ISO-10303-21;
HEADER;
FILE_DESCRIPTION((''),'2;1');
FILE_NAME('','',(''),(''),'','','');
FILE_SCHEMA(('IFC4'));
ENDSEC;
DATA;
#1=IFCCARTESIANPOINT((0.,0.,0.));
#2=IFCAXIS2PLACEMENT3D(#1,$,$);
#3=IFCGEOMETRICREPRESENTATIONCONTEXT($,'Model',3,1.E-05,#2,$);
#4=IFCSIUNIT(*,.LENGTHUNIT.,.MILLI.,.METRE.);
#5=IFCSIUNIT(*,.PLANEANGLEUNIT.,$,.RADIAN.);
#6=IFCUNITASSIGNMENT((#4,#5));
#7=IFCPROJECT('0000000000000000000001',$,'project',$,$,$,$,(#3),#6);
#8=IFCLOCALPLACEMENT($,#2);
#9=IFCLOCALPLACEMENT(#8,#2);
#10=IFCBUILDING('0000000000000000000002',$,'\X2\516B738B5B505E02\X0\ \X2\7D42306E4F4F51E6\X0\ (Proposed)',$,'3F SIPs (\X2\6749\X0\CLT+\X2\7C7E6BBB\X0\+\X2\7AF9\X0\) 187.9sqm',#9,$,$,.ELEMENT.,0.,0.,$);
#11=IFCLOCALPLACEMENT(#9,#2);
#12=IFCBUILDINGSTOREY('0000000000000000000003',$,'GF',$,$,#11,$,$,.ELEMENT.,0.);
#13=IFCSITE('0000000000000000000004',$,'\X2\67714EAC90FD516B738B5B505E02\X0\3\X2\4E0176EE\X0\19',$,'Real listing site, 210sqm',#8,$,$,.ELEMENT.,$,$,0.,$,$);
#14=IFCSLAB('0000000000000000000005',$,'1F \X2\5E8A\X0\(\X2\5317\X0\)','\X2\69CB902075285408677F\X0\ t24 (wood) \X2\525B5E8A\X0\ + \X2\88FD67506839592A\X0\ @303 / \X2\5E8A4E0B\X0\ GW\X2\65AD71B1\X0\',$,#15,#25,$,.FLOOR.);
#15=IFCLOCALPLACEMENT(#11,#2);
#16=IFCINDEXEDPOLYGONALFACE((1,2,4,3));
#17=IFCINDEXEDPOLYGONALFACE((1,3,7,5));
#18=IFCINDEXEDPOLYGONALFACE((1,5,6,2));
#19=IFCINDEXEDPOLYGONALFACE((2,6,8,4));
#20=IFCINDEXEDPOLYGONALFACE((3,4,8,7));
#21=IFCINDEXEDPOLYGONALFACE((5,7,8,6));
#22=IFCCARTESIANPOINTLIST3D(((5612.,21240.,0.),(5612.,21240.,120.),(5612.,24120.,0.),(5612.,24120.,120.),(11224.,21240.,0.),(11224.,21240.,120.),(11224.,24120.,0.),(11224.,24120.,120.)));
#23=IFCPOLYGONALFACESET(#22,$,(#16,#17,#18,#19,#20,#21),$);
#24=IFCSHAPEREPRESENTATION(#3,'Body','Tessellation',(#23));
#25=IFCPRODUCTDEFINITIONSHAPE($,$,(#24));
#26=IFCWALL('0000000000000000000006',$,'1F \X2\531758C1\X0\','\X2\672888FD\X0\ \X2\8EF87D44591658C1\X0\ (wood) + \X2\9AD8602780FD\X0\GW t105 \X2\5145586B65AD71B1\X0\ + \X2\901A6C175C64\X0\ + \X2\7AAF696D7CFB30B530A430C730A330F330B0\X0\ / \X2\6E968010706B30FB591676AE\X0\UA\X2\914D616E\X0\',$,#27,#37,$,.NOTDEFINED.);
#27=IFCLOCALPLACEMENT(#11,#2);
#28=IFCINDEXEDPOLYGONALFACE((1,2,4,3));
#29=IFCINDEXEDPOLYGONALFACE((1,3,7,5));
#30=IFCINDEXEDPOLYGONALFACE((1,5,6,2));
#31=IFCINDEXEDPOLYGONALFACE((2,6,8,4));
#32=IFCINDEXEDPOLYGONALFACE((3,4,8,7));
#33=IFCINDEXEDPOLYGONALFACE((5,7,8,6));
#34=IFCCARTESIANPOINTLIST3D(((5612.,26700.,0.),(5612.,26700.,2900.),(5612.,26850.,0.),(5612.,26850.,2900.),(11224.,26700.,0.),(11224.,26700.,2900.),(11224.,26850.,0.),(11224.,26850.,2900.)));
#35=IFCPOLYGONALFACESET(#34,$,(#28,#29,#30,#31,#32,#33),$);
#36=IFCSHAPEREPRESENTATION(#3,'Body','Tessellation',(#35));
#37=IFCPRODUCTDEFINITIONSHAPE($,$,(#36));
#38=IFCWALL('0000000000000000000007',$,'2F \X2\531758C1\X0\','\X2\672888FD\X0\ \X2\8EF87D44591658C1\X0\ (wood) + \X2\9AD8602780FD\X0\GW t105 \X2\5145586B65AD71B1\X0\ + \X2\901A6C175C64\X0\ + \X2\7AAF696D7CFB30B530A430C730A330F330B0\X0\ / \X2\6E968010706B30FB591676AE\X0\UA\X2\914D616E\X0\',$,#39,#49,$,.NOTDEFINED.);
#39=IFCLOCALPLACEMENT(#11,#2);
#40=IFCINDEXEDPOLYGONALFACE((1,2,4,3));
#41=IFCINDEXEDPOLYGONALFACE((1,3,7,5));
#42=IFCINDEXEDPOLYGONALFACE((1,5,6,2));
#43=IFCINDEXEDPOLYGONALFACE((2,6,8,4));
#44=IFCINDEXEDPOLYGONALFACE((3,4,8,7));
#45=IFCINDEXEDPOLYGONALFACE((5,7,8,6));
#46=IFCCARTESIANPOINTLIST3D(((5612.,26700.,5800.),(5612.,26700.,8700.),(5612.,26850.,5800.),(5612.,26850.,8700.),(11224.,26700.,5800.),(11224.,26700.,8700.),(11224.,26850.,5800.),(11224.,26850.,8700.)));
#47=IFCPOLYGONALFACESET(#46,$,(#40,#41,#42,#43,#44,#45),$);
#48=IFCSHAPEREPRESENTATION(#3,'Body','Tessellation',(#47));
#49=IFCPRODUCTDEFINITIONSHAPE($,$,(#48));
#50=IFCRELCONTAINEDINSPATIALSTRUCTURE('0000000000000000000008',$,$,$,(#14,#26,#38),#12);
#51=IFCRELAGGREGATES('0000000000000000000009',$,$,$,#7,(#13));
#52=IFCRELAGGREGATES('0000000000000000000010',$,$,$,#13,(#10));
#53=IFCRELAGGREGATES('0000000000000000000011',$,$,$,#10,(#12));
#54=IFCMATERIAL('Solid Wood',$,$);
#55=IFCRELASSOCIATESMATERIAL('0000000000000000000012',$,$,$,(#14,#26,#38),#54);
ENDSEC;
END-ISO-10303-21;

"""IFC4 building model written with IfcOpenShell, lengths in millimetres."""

from ifc_helpers import new_model, si_unit, frame, frame_2d, origin, place, context, project, spatial, rectangle, extrude, material, element, save


model = new_model("IFC4")

# Units and contexts
model_context = context("Model", 3, precision=1e-05, world=origin())
ifc_project = project(units=[si_unit("LENGTHUNIT", "METRE", prefix="MILLI"), si_unit("PLANEANGLEUNIT", "RADIAN")], contexts=[model_context])

# Site, building, storey
site_placement = place(None, origin())
site = spatial("IfcSite", under=ifc_project, at=site_placement, Name="東京都八王子市3丁目19", ObjectType="Real listing site, 210sqm", CompositionType="ELEMENT", RefElevation=0.0)
building_placement = place(site_placement, origin())
building = spatial("IfcBuilding", under=site, at=building_placement, Name="八王子市 終の住処 (Proposed)", ObjectType="3F SIPs (杉CLT+籾殻+竹) 187.9sqm", CompositionType="ELEMENT", ElevationOfRefHeight=0.0, ElevationOfTerrain=0.0)
storey_placement = place(building_placement, origin())
storey = spatial("IfcBuildingStorey", under=building, at=storey_placement, Name="GF", CompositionType="ELEMENT", Elevation=0.0)

# Slab
ifc_material_1 = material(Name="Solid Wood")
slab_1_placement = place(storey_placement, frame((2806.0, 10620.0, 0.0)))
element("IfcSlab", 1, at=slab_1_placement, inside=storey, material=ifc_material_1, Name="1F 床(北)", Description="構造用合板 t24 (wood) 剛床 + 製材根太 @303 / 床下 GW断熱", PredefinedType="FLOOR", context=model_context, shape_type="SweptSolid", body=[
    extrude(rectangle(XDim=5612.0, YDim=2880.0, at=frame_2d((2806.0, 1440.0))), frame((2806.0, 10620.0, 0.0)), (0.0, 0.0, 1.0), 120.0),
])

# Wall
wall_1_placement = place(storey_placement, frame((2806.0, 13350.0, 0.0)))
element("IfcWall", 2, at=wall_1_placement, inside=storey, material=ifc_material_1, Name="1F 北壁", Description="木製 軸組外壁 (wood) + 高性能GW t105 充填断熱 + 通気層 + 窯業系サイディング / 準耐火・外皮UA配慮", PredefinedType="NOTDEFINED", context=model_context, shape_type="SweptSolid", body=[
    extrude(rectangle(XDim=5612.0, YDim=150.0, at=frame_2d((2806.0, 75.0))), frame((2806.0, 13350.0, 0.0)), (0.0, 0.0, 1.0), 2900.0),
])

# Wall
wall_2_placement = place(storey_placement, frame((2806.0, 13350.0, 2900.0)))
element("IfcWall", 3, at=wall_2_placement, inside=storey, material=ifc_material_1, Name="2F 北壁", Description="木製 軸組外壁 (wood) + 高性能GW t105 充填断熱 + 通気層 + 窯業系サイディング / 準耐火・外皮UA配慮", PredefinedType="NOTDEFINED", context=model_context, shape_type="SweptSolid", body=[
    extrude(rectangle(XDim=5612.0, YDim=150.0, at=frame_2d((2806.0, 75.0))), frame((2806.0, 13350.0, 2900.0)), (0.0, 0.0, 1.0), 2900.0),
])

save(model, "model.ifc")
